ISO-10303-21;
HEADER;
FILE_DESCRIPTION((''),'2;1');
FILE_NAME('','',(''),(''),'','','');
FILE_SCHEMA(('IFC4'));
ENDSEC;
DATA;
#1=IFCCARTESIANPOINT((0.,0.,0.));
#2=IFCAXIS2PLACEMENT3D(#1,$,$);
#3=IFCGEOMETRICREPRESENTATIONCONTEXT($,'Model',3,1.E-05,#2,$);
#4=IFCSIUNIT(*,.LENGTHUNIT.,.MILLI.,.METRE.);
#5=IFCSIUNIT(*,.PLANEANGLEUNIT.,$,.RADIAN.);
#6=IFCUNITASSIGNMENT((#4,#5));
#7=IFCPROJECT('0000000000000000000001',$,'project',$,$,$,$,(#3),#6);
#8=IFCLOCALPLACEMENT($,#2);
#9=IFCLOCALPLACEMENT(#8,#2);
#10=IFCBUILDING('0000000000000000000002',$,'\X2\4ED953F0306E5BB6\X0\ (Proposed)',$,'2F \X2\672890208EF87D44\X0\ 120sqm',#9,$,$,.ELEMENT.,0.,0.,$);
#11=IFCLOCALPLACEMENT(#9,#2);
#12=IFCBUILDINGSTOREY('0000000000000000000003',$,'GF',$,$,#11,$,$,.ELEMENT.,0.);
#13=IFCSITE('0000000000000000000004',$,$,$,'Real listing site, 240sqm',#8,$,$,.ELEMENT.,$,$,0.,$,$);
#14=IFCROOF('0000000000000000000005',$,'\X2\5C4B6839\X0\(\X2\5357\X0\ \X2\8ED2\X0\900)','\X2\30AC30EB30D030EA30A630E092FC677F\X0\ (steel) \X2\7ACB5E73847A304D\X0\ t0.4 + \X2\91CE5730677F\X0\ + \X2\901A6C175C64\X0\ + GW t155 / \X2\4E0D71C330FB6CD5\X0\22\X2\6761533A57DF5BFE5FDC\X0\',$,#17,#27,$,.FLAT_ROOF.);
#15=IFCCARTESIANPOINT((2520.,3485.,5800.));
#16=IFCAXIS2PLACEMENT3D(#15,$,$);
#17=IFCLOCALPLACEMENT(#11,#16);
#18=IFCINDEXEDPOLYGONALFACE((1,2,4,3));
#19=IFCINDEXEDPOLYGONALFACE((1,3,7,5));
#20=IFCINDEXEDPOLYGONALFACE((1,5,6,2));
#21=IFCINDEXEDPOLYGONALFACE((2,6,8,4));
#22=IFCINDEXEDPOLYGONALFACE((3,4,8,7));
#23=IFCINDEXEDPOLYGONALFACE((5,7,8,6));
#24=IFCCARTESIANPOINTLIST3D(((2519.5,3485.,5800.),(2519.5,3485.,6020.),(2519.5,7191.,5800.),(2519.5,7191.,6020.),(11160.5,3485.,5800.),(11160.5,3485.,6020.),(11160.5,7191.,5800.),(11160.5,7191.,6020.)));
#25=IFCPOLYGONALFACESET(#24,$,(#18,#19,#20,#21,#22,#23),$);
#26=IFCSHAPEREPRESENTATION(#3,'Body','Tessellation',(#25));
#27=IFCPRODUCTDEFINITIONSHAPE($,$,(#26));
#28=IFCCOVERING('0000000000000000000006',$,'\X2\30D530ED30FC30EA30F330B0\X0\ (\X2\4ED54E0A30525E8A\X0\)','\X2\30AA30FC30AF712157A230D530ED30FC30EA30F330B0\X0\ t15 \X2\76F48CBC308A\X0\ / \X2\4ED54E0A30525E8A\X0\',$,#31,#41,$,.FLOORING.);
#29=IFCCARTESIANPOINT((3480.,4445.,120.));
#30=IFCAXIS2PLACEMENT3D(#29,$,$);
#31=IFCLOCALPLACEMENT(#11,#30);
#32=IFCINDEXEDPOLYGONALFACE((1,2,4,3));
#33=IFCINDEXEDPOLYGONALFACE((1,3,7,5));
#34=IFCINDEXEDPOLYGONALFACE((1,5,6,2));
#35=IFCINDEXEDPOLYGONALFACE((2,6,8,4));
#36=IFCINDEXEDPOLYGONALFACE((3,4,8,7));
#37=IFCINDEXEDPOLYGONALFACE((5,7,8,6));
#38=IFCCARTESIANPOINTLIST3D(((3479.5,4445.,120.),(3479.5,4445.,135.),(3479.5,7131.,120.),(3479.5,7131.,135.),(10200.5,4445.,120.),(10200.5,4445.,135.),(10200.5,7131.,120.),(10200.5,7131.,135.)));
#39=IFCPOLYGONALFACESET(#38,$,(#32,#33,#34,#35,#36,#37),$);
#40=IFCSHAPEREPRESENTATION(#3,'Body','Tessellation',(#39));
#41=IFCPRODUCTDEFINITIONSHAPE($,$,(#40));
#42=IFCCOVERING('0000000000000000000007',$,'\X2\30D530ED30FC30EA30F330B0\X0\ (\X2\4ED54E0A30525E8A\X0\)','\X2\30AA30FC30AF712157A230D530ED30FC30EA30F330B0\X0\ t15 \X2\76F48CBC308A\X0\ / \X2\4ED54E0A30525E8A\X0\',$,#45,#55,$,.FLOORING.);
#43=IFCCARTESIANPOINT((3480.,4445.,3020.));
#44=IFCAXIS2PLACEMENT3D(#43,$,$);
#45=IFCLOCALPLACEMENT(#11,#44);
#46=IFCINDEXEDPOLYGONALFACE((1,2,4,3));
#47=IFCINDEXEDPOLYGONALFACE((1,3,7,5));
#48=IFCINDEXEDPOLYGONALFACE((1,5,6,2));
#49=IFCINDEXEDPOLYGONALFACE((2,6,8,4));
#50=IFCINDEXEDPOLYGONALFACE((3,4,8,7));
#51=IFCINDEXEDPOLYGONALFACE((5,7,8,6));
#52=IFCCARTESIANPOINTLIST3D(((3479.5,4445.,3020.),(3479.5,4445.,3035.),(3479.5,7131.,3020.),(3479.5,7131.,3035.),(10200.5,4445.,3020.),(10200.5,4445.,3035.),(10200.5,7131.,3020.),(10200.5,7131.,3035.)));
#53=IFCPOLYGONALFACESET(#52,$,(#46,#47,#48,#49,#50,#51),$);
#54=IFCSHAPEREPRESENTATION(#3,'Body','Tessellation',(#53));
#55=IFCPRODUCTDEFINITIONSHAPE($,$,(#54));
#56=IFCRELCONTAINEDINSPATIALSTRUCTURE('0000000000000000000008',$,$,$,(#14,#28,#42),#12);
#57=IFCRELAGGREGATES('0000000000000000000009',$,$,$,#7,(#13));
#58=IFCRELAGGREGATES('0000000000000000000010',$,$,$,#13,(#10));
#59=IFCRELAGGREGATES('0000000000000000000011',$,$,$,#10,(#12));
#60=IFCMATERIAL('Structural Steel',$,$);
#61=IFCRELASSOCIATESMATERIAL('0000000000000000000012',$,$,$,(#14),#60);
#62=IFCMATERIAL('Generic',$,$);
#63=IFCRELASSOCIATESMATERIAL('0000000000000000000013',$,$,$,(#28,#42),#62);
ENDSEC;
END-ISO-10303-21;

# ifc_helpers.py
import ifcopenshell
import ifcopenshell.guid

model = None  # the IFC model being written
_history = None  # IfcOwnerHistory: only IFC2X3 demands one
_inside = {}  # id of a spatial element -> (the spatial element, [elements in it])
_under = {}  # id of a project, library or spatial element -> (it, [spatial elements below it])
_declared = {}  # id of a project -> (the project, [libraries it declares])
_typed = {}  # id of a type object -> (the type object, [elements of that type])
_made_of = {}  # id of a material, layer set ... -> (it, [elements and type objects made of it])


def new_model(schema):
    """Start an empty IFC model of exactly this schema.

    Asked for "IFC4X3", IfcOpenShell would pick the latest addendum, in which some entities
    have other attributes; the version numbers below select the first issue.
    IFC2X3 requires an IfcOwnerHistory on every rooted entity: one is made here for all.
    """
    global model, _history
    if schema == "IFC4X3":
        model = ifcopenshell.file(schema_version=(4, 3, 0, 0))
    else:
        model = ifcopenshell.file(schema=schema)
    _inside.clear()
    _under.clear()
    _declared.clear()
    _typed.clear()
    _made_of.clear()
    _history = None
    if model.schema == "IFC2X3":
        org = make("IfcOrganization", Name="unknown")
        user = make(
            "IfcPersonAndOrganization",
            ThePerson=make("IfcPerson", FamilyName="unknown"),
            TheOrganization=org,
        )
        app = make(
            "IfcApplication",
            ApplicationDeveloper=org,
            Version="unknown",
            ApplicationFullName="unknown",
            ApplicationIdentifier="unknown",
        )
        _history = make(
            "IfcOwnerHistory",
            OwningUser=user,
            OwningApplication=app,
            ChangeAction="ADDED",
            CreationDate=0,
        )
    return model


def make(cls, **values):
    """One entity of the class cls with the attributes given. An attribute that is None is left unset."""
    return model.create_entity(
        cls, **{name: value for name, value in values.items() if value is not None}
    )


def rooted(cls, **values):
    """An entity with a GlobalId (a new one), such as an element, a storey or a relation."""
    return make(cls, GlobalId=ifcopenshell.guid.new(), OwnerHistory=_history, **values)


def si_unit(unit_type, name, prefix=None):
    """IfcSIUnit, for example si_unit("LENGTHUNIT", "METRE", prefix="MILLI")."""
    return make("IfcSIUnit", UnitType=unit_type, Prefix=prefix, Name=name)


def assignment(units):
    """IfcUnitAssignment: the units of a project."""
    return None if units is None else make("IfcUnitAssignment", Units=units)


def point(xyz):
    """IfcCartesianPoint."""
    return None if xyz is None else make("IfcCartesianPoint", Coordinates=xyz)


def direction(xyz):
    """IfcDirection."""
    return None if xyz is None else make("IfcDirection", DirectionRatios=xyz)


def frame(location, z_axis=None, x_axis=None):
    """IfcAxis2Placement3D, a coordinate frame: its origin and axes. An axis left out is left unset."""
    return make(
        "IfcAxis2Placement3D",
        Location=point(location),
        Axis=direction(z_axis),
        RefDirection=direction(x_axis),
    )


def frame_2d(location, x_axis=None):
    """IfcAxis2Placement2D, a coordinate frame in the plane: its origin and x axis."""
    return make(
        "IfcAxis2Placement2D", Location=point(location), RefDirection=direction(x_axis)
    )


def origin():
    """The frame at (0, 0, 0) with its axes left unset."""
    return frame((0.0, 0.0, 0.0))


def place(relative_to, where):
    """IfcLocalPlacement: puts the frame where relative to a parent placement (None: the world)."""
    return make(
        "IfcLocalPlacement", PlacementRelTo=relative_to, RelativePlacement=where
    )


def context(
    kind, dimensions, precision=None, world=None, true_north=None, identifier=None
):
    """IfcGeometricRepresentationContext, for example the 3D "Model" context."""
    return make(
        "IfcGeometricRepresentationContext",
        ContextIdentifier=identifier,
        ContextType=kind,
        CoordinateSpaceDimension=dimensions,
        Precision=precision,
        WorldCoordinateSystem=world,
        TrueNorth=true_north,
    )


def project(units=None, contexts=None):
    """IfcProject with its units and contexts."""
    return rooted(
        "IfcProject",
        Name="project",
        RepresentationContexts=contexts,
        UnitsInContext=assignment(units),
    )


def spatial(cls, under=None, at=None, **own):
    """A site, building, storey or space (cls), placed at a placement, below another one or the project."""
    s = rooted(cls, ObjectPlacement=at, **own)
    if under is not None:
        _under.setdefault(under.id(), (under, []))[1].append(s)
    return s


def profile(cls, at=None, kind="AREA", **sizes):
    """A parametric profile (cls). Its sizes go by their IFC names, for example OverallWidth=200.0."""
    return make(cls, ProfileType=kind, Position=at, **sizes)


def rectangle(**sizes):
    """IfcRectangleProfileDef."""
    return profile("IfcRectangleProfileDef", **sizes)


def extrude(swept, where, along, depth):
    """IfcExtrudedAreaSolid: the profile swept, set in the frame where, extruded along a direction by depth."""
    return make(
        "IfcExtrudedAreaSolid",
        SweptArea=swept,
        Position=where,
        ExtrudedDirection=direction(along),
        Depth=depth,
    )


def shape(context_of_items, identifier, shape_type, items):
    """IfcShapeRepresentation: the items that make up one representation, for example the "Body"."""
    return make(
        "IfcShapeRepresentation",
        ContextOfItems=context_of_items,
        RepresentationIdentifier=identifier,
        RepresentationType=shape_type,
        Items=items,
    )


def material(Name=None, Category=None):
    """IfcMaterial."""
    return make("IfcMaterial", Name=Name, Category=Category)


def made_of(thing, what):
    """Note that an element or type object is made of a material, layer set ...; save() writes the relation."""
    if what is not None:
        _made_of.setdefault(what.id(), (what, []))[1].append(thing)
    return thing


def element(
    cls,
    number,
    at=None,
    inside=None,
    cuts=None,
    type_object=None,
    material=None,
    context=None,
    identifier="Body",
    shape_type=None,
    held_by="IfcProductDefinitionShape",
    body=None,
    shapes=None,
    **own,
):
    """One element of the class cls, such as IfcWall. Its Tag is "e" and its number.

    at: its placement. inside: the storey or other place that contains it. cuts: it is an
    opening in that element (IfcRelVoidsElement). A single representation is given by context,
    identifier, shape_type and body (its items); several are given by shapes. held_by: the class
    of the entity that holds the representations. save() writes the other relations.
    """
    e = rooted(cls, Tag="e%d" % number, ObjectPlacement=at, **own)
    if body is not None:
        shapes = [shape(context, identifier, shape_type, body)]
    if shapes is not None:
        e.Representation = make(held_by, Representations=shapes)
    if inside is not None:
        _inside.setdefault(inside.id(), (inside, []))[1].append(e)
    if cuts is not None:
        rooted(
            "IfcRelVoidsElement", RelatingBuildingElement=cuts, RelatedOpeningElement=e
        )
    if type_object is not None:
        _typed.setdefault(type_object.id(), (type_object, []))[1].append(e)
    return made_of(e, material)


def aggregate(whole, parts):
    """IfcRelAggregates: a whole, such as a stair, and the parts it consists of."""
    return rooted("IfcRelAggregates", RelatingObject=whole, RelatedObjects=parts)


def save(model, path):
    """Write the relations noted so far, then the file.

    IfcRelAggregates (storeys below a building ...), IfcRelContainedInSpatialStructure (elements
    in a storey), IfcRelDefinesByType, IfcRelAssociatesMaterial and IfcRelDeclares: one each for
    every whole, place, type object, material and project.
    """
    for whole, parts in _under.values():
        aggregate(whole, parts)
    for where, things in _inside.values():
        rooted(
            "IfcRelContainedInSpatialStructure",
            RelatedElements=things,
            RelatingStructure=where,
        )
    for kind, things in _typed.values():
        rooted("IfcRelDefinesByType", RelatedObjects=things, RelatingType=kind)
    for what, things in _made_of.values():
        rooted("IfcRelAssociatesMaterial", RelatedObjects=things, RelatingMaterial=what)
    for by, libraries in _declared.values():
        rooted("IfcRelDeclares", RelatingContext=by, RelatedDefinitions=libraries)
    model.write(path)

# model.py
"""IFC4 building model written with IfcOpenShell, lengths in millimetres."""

from ifc_helpers import new_model, si_unit, frame, frame_2d, origin, place, context, project, spatial, rectangle, extrude, material, element, save


model = new_model("IFC4")

# Units and contexts
model_context = context("Model", 3, precision=1e-05, world=origin())
ifc_project = project(units=[si_unit("LENGTHUNIT", "METRE", prefix="MILLI"), si_unit("PLANEANGLEUNIT", "RADIAN")], contexts=[model_context])

# Site, building, storey
site_placement = place(None, origin())
site = spatial("IfcSite", under=ifc_project, at=site_placement, ObjectType="Real listing site, 240sqm", CompositionType="ELEMENT", RefElevation=0.0)
building_placement = place(site_placement, origin())
building = spatial("IfcBuilding", under=site, at=building_placement, Name="仙台の家 (Proposed)", ObjectType="2F 木造軸組 120sqm", CompositionType="ELEMENT", ElevationOfRefHeight=0.0, ElevationOfTerrain=0.0)
storey_placement = place(building_placement, origin())
storey = spatial("IfcBuildingStorey", under=building, at=storey_placement, Name="GF", CompositionType="ELEMENT", Elevation=0.0)

# Roof
ifc_material_1 = material(Name="Structural Steel")
roof_1_placement = place(storey_placement, frame((2520.0, 3485.0, 5800.0)))
element("IfcRoof", 1, at=roof_1_placement, inside=storey, material=ifc_material_1, Name="屋根(南 軒900)", Description="ガルバリウム鋼板 (steel) 立平葺き t0.4 + 野地板 + 通気層 + GW t155 / 不燃・法22条区域対応", PredefinedType="FLAT_ROOF", context=model_context, shape_type="SweptSolid", body=[
    extrude(rectangle(XDim=8641.0, YDim=3706.0, at=frame_2d((4320.0, 1853.0))), frame((2520.0, 3485.0, 5800.0)), (0.0, 0.0, 1.0), 220.0),
])

# Coverings
ifc_material_2 = material(Name="Generic")
covering_1_placement = place(storey_placement, frame((3480.0, 4445.0, 120.0)))
element("IfcCovering", 2, at=covering_1_placement, inside=storey, material=ifc_material_2, Name="フローリング (仕上げ床)", Description="オーク無垢フローリング t15 直貼り / 仕上げ床", PredefinedType="FLOORING", context=model_context, shape_type="SweptSolid", body=[
    extrude(rectangle(XDim=6721.0, YDim=2686.0, at=frame_2d((3360.0, 1343.0))), frame((3480.0, 4445.0, 120.0)), (0.0, 0.0, 1.0), 15.0),
])
covering_2_placement = place(storey_placement, frame((3480.0, 4445.0, 3020.0)))
element("IfcCovering", 3, at=covering_2_placement, inside=storey, material=ifc_material_2, Name="フローリング (仕上げ床)", Description="オーク無垢フローリング t15 直貼り / 仕上げ床", PredefinedType="FLOORING", context=model_context, shape_type="SweptSolid", body=[
    extrude(rectangle(XDim=6721.0, YDim=2686.0, at=frame_2d((3360.0, 1343.0))), frame((3480.0, 4445.0, 3020.0)), (0.0, 0.0, 1.0), 15.0),
])

save(model, "model.ifc")
